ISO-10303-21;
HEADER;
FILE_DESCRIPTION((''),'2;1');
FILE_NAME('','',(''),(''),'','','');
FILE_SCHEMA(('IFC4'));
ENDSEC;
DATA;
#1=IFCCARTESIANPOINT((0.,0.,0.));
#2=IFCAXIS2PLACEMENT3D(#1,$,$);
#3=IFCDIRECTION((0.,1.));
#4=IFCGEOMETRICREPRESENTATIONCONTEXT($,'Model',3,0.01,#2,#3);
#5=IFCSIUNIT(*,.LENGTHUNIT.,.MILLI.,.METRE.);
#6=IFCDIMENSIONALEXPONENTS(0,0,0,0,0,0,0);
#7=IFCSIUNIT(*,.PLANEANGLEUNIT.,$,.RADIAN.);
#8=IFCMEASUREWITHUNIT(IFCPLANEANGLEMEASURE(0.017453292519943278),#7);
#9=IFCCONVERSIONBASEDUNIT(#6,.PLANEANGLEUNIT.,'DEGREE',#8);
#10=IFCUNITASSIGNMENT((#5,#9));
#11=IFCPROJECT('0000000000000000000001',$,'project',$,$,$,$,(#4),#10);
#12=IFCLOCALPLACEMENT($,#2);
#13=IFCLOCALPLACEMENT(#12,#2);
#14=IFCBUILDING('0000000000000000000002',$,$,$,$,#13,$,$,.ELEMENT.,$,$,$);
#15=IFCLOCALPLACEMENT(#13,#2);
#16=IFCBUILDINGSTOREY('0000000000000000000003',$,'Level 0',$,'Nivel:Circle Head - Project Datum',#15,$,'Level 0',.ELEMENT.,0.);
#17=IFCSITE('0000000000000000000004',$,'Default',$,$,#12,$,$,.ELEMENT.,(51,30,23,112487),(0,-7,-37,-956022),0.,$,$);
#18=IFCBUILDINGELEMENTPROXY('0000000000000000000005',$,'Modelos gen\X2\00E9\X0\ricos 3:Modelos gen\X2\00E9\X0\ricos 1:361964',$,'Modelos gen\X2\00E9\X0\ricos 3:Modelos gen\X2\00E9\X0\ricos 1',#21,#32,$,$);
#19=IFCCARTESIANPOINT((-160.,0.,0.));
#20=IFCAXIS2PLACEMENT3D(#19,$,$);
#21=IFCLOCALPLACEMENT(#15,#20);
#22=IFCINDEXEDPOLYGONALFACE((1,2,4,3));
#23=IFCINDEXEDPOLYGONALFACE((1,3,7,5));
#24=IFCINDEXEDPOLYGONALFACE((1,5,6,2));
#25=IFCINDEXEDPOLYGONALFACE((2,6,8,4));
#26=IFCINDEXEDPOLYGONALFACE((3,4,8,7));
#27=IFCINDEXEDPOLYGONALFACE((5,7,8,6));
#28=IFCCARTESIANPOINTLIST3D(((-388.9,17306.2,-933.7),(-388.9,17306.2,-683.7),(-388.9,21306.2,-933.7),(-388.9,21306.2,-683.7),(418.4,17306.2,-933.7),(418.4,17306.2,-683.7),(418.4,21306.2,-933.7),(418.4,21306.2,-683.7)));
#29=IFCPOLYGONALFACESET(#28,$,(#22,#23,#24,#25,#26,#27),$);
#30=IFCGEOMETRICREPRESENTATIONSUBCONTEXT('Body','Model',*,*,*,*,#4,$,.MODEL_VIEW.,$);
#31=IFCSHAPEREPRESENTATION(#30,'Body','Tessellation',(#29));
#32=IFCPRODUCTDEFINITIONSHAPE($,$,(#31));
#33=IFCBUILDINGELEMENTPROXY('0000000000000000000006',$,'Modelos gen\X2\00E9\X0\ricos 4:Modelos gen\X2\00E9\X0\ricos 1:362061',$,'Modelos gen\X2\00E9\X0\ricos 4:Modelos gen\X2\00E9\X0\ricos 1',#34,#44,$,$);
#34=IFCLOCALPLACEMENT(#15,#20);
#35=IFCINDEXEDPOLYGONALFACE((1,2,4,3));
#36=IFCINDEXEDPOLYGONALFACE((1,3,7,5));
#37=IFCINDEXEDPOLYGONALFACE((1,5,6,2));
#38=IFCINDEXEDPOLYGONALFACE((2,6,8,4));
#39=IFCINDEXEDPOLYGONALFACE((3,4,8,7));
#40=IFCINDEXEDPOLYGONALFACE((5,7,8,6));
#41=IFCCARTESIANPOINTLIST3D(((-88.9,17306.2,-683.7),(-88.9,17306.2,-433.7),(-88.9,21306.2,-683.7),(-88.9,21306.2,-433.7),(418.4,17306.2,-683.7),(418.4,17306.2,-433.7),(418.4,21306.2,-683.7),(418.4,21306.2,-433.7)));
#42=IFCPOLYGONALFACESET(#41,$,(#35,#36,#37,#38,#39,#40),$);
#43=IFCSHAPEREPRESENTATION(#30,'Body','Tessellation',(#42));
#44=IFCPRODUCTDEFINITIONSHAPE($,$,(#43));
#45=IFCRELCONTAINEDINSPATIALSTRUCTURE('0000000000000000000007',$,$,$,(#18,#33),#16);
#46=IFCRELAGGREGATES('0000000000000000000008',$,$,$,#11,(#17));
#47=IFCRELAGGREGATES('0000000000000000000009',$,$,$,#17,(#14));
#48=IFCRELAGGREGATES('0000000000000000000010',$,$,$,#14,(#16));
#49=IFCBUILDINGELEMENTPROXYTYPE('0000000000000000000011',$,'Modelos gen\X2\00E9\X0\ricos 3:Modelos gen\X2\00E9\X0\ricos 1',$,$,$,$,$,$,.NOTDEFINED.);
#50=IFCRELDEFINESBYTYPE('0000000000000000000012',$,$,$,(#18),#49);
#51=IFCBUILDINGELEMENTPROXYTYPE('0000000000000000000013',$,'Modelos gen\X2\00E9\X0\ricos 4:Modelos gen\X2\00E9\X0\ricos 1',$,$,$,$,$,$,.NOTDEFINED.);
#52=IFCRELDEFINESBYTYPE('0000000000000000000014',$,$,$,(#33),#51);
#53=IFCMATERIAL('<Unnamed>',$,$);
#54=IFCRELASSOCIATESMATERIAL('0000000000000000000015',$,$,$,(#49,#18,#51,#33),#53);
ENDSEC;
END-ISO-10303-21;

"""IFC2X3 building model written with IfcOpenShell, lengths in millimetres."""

from ifc_helpers import new_model, entity, si_unit, converted_unit, direction, frame, frame_2d, origin, place, context, subcontext, project, spatial, rectangle, extrude, source, transform, mapped, material, type_object, type_shapes, element, save


model = new_model("IFC2X3")

# Units and contexts
model_context = context("Model", 3, precision=0.01, world=origin(), true_north=direction((0.0, 1.0)))
body_context = subcontext(model_context, "Body", "Model", "MODEL_VIEW")
ifc_project = project(units=[si_unit("LENGTHUNIT", "METRE", prefix="MILLI"), converted_unit("PLANEANGLEUNIT", "DEGREE", entity("IfcPlaneAngleMeasure", 0.017453292519943278), si_unit("PLANEANGLEUNIT", "RADIAN"), dimensions=[0, 0, 0, 0, 0, 0, 0])], contexts=[model_context])

# Site, building, storey
site_placement = place(None, origin())
site = spatial("IfcSite", under=ifc_project, at=site_placement, Name="Default", CompositionType="ELEMENT", RefLatitude=(51, 30, 23, 112487), RefLongitude=(0, -7, -37, -956022), RefElevation=0.0)
building_placement = place(site_placement, origin())
building = spatial("IfcBuilding", under=site, at=building_placement, CompositionType="ELEMENT")
storey_placement = place(building_placement, origin())
storey = spatial("IfcBuildingStorey", under=building, at=storey_placement, Name="Level 0", ObjectType="Nivel:Circle Head - Project Datum", LongName="Level 0", CompositionType="ELEMENT", Elevation=0.0)

# Shared definitions
ifc_material_1 = material(Name="<Unnamed>")

# Building element proxies
building_element_proxy_type_1 = type_object("IfcBuildingElementProxyType", Name="Modelos genéricos 3:Modelos genéricos 1", PredefinedType="NOTDEFINED", material=ifc_material_1)
shared_shape_1 = source(origin(), body_context, "Body", "SweptSolid", [
    extrude(rectangle(XDim=4000.0, YDim=807.2, at=frame_2d((0.0, 0.0), x_axis=(1.0, 0.0))), frame((14.8, 19306.2, -933.7), z_axis=(0.0, 0.0, 1.0), x_axis=(0.0, -1.0, 0.0)), (0.0, 0.0, 1.0), 250.0),
])
type_shapes(building_element_proxy_type_1, [shared_shape_1])
proxy_1_placement = place(storey_placement, frame((-160.0, 0.0, 0.0)))
element("IfcBuildingElementProxy", 1, at=proxy_1_placement, inside=storey, type_object=building_element_proxy_type_1, material=ifc_material_1, Name="Modelos genéricos 3:Modelos genéricos 1:361964", ObjectType="Modelos genéricos 3:Modelos genéricos 1", context=body_context, shape_type="MappedRepresentation", body=[
    mapped(shared_shape_1, transform((0.0, 0.0, 0.0), scale=1.0)),
])
building_element_proxy_type_2 = type_object("IfcBuildingElementProxyType", Name="Modelos genéricos 4:Modelos genéricos 1", PredefinedType="NOTDEFINED", material=ifc_material_1)
shared_shape_2 = source(origin(), body_context, "Body", "SweptSolid", [
    extrude(rectangle(XDim=4000.0, YDim=507.2, at=frame_2d((0.0, 0.0), x_axis=(1.0, 0.0))), frame((164.8, 19306.2, -683.7), z_axis=(0.0, 0.0, 1.0), x_axis=(0.0, -1.0, 0.0)), (0.0, 0.0, 1.0), 250.0),
])
type_shapes(building_element_proxy_type_2, [shared_shape_2])
proxy_2_placement = place(storey_placement, frame((-160.0, 0.0, 0.0)))
element("IfcBuildingElementProxy", 2, at=proxy_2_placement, inside=storey, type_object=building_element_proxy_type_2, material=ifc_material_1, Name="Modelos genéricos 4:Modelos genéricos 1:362061", ObjectType="Modelos genéricos 4:Modelos genéricos 1", context=body_context, shape_type="MappedRepresentation", body=[
    mapped(shared_shape_2, transform((0.0, 0.0, 0.0), scale=1.0)),
])

save(model, "model.ifc")
